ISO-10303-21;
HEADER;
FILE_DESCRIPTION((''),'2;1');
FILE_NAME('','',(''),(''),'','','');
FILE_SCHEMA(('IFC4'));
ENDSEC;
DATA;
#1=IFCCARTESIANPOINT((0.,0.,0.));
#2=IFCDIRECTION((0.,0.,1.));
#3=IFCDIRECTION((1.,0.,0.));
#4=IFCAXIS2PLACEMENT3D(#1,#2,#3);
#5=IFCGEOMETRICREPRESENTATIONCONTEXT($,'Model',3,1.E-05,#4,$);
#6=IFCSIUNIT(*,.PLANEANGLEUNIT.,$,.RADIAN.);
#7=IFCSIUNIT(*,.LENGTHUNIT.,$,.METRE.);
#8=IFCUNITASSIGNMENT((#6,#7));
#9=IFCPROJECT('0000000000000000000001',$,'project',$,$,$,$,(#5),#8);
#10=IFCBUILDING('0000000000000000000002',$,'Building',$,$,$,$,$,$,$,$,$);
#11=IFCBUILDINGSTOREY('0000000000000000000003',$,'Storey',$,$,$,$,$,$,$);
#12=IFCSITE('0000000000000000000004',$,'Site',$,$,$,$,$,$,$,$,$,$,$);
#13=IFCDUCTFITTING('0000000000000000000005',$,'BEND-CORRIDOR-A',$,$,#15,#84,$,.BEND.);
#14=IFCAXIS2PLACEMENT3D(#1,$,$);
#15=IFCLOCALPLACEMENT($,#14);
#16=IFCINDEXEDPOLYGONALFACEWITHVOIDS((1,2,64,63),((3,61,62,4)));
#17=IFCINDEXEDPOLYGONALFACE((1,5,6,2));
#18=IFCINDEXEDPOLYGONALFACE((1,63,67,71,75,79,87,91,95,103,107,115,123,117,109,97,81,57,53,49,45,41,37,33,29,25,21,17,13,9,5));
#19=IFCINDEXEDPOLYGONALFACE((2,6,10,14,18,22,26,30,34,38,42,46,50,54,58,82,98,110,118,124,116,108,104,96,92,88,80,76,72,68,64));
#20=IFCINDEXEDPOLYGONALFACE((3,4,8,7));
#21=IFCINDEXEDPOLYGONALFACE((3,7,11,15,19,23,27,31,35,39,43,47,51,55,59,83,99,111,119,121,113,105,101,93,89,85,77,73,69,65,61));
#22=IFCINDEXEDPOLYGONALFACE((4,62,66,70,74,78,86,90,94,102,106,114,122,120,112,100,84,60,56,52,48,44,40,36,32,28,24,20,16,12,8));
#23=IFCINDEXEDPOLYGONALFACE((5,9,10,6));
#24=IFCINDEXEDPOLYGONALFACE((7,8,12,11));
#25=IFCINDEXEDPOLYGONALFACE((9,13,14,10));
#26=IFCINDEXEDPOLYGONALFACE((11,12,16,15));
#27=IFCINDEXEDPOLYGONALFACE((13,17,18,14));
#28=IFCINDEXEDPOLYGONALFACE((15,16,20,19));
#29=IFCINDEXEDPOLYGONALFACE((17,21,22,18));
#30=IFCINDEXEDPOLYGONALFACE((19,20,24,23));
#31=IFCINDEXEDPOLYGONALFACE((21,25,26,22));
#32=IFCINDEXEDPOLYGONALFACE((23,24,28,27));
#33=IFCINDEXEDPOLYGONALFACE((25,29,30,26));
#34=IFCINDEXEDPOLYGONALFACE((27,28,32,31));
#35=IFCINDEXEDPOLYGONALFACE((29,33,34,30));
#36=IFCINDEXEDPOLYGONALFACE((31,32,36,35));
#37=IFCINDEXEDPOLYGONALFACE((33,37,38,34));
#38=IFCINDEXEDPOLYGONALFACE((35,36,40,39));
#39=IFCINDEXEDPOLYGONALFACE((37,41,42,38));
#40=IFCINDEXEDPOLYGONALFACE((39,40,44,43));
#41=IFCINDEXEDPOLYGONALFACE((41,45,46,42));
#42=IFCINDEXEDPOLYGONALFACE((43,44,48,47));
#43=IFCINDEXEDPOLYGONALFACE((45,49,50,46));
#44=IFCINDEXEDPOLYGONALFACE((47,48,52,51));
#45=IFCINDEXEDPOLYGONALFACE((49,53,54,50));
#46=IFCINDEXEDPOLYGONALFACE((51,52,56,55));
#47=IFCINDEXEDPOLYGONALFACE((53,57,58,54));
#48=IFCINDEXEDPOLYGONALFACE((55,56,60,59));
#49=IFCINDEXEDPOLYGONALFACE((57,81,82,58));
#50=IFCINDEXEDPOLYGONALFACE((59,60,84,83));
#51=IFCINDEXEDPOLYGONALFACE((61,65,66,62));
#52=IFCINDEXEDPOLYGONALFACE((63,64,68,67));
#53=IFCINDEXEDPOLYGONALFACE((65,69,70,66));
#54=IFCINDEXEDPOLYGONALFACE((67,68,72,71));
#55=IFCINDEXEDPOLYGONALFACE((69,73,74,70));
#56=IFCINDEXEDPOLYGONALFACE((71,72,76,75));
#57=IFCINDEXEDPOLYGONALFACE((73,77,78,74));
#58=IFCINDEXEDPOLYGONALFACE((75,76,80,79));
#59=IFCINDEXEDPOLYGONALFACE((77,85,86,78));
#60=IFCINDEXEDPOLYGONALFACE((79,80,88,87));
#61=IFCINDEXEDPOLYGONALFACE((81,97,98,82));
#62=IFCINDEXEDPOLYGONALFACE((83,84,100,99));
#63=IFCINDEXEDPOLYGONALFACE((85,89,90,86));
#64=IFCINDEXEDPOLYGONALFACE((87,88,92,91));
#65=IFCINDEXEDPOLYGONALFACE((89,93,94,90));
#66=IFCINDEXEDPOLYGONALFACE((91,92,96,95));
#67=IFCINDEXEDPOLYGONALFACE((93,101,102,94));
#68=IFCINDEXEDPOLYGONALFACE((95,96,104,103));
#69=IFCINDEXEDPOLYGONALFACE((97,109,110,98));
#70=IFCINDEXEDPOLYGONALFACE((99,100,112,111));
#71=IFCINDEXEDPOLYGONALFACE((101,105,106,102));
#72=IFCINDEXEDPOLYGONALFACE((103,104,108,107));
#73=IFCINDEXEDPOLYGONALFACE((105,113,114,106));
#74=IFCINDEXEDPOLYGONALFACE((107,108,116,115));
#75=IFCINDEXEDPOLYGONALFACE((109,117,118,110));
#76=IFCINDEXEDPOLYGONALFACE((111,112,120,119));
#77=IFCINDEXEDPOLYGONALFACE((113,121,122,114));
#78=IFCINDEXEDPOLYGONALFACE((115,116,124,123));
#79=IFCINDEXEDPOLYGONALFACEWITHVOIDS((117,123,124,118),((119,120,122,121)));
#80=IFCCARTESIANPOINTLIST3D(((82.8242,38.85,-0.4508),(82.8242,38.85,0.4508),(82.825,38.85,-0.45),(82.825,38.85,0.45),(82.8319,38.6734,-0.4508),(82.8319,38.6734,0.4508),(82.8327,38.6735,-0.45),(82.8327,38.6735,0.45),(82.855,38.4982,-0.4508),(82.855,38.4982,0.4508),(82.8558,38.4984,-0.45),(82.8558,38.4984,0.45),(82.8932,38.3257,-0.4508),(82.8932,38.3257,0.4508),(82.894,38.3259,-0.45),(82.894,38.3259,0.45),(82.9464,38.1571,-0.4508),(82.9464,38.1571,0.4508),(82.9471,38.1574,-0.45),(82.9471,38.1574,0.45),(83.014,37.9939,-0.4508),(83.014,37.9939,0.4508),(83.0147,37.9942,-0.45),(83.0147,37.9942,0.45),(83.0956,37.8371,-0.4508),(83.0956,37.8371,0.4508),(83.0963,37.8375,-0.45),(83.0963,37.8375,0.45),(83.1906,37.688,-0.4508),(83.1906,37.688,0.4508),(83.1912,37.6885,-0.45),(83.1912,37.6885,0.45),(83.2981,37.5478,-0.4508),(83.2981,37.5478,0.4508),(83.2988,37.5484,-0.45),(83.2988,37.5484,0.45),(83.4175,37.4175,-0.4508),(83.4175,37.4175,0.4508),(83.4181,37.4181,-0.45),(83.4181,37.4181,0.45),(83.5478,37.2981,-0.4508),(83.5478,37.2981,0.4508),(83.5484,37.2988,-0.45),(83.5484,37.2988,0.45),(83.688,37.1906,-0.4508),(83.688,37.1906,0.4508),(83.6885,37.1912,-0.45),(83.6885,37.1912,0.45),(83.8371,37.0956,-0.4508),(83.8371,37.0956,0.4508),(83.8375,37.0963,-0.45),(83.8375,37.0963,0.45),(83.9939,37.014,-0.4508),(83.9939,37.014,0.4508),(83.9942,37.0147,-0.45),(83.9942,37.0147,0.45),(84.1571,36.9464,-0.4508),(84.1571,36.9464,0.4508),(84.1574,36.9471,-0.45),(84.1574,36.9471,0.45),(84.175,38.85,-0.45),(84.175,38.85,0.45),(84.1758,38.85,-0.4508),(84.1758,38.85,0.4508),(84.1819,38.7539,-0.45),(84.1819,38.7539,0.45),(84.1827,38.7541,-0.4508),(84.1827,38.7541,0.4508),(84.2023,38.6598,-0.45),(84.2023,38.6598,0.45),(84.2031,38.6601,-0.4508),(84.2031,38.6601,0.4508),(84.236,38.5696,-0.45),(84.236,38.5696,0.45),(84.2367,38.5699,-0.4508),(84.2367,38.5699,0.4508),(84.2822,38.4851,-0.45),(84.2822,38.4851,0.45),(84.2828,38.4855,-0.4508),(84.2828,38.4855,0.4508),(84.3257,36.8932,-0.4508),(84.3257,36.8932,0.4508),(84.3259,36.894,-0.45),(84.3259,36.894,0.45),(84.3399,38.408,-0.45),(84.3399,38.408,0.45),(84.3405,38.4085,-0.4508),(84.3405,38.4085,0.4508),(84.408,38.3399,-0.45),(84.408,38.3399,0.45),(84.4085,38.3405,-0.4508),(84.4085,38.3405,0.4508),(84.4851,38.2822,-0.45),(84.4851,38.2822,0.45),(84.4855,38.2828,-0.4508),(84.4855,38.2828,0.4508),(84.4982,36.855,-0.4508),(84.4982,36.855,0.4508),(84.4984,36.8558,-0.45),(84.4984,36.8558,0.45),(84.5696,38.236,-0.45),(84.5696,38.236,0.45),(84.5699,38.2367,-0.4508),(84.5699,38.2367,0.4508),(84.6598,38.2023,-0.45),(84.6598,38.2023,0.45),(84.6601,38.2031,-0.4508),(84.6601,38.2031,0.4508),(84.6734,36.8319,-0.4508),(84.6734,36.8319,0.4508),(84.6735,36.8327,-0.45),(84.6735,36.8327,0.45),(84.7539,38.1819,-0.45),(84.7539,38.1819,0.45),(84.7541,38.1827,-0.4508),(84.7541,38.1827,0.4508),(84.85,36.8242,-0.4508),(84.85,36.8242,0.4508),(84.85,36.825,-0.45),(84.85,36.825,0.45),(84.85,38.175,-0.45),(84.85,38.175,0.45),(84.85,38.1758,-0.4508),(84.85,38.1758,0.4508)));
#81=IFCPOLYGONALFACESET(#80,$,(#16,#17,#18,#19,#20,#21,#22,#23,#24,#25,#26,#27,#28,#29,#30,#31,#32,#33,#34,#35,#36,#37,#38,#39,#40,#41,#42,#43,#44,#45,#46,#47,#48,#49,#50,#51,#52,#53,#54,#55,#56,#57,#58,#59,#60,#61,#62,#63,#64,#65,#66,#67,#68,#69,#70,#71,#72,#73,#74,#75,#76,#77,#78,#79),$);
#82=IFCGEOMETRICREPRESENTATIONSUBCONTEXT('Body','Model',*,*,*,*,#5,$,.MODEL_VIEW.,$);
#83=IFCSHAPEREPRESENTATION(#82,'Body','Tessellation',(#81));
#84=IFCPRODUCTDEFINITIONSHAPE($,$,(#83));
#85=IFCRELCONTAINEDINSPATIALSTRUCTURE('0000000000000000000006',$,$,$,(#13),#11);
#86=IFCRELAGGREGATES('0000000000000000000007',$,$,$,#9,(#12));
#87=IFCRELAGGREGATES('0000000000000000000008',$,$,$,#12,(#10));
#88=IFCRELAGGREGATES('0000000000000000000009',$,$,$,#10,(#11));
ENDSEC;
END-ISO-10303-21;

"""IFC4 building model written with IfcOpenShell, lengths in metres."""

from ifc_helpers import new_model, entity, si_unit, frame, origin_with_axes, place, context, subcontext, project, spatial, element, save


model = new_model("IFC4")

# Units and contexts
model_context = context("Model", 3, precision=1e-05, world=origin_with_axes())
body_context = subcontext(model_context, "Body", "Model", "MODEL_VIEW")
ifc_project = project(units=[si_unit("PLANEANGLEUNIT", "RADIAN"), si_unit("LENGTHUNIT", "METRE")], contexts=[model_context])

# Site, building, storey
site = spatial("IfcSite", under=ifc_project, Name="Site")
building = spatial("IfcBuilding", under=site, Name="Building")
storey = spatial("IfcBuildingStorey", under=building, Name="Storey")

# Duct fitting
duct_fitting_1_placement = place(None, frame((84.85, 38.85, 0.0), z_axis=(0.0, 0.0, 1.0), x_axis=(-1.0, 0.0, 0.0)))
cartesian_point_1 = entity("IfcCartesianPoint", [0.0, 0.0, 0.0])
element("IfcDuctFitting", 1, at=duct_fitting_1_placement, inside=storey, Name="BEND-CORRIDOR-A", PredefinedType="BEND", context=body_context, shape_type="SweptSolid", body=[
    entity("IfcRevolvedAreaSolid", entity("IfcRectangleHollowProfileDef", "AREA", None, entity("IfcAxis2Placement2D", entity("IfcCartesianPoint", [1.35, 0.0])), 1.3516, 0.9016, 0.0008), entity("IfcAxis2Placement3D", cartesian_point_1, entity("IfcDirection", [0.0, -1.0, 0.0]), entity("IfcDirection", [1.0, 0.0, 0.0])), entity("IfcAxis1Placement", cartesian_point_1, entity("IfcDirection", [0.0, 1.0, 0.0])), 1.570796),
])

save(model, "model.ifc")
